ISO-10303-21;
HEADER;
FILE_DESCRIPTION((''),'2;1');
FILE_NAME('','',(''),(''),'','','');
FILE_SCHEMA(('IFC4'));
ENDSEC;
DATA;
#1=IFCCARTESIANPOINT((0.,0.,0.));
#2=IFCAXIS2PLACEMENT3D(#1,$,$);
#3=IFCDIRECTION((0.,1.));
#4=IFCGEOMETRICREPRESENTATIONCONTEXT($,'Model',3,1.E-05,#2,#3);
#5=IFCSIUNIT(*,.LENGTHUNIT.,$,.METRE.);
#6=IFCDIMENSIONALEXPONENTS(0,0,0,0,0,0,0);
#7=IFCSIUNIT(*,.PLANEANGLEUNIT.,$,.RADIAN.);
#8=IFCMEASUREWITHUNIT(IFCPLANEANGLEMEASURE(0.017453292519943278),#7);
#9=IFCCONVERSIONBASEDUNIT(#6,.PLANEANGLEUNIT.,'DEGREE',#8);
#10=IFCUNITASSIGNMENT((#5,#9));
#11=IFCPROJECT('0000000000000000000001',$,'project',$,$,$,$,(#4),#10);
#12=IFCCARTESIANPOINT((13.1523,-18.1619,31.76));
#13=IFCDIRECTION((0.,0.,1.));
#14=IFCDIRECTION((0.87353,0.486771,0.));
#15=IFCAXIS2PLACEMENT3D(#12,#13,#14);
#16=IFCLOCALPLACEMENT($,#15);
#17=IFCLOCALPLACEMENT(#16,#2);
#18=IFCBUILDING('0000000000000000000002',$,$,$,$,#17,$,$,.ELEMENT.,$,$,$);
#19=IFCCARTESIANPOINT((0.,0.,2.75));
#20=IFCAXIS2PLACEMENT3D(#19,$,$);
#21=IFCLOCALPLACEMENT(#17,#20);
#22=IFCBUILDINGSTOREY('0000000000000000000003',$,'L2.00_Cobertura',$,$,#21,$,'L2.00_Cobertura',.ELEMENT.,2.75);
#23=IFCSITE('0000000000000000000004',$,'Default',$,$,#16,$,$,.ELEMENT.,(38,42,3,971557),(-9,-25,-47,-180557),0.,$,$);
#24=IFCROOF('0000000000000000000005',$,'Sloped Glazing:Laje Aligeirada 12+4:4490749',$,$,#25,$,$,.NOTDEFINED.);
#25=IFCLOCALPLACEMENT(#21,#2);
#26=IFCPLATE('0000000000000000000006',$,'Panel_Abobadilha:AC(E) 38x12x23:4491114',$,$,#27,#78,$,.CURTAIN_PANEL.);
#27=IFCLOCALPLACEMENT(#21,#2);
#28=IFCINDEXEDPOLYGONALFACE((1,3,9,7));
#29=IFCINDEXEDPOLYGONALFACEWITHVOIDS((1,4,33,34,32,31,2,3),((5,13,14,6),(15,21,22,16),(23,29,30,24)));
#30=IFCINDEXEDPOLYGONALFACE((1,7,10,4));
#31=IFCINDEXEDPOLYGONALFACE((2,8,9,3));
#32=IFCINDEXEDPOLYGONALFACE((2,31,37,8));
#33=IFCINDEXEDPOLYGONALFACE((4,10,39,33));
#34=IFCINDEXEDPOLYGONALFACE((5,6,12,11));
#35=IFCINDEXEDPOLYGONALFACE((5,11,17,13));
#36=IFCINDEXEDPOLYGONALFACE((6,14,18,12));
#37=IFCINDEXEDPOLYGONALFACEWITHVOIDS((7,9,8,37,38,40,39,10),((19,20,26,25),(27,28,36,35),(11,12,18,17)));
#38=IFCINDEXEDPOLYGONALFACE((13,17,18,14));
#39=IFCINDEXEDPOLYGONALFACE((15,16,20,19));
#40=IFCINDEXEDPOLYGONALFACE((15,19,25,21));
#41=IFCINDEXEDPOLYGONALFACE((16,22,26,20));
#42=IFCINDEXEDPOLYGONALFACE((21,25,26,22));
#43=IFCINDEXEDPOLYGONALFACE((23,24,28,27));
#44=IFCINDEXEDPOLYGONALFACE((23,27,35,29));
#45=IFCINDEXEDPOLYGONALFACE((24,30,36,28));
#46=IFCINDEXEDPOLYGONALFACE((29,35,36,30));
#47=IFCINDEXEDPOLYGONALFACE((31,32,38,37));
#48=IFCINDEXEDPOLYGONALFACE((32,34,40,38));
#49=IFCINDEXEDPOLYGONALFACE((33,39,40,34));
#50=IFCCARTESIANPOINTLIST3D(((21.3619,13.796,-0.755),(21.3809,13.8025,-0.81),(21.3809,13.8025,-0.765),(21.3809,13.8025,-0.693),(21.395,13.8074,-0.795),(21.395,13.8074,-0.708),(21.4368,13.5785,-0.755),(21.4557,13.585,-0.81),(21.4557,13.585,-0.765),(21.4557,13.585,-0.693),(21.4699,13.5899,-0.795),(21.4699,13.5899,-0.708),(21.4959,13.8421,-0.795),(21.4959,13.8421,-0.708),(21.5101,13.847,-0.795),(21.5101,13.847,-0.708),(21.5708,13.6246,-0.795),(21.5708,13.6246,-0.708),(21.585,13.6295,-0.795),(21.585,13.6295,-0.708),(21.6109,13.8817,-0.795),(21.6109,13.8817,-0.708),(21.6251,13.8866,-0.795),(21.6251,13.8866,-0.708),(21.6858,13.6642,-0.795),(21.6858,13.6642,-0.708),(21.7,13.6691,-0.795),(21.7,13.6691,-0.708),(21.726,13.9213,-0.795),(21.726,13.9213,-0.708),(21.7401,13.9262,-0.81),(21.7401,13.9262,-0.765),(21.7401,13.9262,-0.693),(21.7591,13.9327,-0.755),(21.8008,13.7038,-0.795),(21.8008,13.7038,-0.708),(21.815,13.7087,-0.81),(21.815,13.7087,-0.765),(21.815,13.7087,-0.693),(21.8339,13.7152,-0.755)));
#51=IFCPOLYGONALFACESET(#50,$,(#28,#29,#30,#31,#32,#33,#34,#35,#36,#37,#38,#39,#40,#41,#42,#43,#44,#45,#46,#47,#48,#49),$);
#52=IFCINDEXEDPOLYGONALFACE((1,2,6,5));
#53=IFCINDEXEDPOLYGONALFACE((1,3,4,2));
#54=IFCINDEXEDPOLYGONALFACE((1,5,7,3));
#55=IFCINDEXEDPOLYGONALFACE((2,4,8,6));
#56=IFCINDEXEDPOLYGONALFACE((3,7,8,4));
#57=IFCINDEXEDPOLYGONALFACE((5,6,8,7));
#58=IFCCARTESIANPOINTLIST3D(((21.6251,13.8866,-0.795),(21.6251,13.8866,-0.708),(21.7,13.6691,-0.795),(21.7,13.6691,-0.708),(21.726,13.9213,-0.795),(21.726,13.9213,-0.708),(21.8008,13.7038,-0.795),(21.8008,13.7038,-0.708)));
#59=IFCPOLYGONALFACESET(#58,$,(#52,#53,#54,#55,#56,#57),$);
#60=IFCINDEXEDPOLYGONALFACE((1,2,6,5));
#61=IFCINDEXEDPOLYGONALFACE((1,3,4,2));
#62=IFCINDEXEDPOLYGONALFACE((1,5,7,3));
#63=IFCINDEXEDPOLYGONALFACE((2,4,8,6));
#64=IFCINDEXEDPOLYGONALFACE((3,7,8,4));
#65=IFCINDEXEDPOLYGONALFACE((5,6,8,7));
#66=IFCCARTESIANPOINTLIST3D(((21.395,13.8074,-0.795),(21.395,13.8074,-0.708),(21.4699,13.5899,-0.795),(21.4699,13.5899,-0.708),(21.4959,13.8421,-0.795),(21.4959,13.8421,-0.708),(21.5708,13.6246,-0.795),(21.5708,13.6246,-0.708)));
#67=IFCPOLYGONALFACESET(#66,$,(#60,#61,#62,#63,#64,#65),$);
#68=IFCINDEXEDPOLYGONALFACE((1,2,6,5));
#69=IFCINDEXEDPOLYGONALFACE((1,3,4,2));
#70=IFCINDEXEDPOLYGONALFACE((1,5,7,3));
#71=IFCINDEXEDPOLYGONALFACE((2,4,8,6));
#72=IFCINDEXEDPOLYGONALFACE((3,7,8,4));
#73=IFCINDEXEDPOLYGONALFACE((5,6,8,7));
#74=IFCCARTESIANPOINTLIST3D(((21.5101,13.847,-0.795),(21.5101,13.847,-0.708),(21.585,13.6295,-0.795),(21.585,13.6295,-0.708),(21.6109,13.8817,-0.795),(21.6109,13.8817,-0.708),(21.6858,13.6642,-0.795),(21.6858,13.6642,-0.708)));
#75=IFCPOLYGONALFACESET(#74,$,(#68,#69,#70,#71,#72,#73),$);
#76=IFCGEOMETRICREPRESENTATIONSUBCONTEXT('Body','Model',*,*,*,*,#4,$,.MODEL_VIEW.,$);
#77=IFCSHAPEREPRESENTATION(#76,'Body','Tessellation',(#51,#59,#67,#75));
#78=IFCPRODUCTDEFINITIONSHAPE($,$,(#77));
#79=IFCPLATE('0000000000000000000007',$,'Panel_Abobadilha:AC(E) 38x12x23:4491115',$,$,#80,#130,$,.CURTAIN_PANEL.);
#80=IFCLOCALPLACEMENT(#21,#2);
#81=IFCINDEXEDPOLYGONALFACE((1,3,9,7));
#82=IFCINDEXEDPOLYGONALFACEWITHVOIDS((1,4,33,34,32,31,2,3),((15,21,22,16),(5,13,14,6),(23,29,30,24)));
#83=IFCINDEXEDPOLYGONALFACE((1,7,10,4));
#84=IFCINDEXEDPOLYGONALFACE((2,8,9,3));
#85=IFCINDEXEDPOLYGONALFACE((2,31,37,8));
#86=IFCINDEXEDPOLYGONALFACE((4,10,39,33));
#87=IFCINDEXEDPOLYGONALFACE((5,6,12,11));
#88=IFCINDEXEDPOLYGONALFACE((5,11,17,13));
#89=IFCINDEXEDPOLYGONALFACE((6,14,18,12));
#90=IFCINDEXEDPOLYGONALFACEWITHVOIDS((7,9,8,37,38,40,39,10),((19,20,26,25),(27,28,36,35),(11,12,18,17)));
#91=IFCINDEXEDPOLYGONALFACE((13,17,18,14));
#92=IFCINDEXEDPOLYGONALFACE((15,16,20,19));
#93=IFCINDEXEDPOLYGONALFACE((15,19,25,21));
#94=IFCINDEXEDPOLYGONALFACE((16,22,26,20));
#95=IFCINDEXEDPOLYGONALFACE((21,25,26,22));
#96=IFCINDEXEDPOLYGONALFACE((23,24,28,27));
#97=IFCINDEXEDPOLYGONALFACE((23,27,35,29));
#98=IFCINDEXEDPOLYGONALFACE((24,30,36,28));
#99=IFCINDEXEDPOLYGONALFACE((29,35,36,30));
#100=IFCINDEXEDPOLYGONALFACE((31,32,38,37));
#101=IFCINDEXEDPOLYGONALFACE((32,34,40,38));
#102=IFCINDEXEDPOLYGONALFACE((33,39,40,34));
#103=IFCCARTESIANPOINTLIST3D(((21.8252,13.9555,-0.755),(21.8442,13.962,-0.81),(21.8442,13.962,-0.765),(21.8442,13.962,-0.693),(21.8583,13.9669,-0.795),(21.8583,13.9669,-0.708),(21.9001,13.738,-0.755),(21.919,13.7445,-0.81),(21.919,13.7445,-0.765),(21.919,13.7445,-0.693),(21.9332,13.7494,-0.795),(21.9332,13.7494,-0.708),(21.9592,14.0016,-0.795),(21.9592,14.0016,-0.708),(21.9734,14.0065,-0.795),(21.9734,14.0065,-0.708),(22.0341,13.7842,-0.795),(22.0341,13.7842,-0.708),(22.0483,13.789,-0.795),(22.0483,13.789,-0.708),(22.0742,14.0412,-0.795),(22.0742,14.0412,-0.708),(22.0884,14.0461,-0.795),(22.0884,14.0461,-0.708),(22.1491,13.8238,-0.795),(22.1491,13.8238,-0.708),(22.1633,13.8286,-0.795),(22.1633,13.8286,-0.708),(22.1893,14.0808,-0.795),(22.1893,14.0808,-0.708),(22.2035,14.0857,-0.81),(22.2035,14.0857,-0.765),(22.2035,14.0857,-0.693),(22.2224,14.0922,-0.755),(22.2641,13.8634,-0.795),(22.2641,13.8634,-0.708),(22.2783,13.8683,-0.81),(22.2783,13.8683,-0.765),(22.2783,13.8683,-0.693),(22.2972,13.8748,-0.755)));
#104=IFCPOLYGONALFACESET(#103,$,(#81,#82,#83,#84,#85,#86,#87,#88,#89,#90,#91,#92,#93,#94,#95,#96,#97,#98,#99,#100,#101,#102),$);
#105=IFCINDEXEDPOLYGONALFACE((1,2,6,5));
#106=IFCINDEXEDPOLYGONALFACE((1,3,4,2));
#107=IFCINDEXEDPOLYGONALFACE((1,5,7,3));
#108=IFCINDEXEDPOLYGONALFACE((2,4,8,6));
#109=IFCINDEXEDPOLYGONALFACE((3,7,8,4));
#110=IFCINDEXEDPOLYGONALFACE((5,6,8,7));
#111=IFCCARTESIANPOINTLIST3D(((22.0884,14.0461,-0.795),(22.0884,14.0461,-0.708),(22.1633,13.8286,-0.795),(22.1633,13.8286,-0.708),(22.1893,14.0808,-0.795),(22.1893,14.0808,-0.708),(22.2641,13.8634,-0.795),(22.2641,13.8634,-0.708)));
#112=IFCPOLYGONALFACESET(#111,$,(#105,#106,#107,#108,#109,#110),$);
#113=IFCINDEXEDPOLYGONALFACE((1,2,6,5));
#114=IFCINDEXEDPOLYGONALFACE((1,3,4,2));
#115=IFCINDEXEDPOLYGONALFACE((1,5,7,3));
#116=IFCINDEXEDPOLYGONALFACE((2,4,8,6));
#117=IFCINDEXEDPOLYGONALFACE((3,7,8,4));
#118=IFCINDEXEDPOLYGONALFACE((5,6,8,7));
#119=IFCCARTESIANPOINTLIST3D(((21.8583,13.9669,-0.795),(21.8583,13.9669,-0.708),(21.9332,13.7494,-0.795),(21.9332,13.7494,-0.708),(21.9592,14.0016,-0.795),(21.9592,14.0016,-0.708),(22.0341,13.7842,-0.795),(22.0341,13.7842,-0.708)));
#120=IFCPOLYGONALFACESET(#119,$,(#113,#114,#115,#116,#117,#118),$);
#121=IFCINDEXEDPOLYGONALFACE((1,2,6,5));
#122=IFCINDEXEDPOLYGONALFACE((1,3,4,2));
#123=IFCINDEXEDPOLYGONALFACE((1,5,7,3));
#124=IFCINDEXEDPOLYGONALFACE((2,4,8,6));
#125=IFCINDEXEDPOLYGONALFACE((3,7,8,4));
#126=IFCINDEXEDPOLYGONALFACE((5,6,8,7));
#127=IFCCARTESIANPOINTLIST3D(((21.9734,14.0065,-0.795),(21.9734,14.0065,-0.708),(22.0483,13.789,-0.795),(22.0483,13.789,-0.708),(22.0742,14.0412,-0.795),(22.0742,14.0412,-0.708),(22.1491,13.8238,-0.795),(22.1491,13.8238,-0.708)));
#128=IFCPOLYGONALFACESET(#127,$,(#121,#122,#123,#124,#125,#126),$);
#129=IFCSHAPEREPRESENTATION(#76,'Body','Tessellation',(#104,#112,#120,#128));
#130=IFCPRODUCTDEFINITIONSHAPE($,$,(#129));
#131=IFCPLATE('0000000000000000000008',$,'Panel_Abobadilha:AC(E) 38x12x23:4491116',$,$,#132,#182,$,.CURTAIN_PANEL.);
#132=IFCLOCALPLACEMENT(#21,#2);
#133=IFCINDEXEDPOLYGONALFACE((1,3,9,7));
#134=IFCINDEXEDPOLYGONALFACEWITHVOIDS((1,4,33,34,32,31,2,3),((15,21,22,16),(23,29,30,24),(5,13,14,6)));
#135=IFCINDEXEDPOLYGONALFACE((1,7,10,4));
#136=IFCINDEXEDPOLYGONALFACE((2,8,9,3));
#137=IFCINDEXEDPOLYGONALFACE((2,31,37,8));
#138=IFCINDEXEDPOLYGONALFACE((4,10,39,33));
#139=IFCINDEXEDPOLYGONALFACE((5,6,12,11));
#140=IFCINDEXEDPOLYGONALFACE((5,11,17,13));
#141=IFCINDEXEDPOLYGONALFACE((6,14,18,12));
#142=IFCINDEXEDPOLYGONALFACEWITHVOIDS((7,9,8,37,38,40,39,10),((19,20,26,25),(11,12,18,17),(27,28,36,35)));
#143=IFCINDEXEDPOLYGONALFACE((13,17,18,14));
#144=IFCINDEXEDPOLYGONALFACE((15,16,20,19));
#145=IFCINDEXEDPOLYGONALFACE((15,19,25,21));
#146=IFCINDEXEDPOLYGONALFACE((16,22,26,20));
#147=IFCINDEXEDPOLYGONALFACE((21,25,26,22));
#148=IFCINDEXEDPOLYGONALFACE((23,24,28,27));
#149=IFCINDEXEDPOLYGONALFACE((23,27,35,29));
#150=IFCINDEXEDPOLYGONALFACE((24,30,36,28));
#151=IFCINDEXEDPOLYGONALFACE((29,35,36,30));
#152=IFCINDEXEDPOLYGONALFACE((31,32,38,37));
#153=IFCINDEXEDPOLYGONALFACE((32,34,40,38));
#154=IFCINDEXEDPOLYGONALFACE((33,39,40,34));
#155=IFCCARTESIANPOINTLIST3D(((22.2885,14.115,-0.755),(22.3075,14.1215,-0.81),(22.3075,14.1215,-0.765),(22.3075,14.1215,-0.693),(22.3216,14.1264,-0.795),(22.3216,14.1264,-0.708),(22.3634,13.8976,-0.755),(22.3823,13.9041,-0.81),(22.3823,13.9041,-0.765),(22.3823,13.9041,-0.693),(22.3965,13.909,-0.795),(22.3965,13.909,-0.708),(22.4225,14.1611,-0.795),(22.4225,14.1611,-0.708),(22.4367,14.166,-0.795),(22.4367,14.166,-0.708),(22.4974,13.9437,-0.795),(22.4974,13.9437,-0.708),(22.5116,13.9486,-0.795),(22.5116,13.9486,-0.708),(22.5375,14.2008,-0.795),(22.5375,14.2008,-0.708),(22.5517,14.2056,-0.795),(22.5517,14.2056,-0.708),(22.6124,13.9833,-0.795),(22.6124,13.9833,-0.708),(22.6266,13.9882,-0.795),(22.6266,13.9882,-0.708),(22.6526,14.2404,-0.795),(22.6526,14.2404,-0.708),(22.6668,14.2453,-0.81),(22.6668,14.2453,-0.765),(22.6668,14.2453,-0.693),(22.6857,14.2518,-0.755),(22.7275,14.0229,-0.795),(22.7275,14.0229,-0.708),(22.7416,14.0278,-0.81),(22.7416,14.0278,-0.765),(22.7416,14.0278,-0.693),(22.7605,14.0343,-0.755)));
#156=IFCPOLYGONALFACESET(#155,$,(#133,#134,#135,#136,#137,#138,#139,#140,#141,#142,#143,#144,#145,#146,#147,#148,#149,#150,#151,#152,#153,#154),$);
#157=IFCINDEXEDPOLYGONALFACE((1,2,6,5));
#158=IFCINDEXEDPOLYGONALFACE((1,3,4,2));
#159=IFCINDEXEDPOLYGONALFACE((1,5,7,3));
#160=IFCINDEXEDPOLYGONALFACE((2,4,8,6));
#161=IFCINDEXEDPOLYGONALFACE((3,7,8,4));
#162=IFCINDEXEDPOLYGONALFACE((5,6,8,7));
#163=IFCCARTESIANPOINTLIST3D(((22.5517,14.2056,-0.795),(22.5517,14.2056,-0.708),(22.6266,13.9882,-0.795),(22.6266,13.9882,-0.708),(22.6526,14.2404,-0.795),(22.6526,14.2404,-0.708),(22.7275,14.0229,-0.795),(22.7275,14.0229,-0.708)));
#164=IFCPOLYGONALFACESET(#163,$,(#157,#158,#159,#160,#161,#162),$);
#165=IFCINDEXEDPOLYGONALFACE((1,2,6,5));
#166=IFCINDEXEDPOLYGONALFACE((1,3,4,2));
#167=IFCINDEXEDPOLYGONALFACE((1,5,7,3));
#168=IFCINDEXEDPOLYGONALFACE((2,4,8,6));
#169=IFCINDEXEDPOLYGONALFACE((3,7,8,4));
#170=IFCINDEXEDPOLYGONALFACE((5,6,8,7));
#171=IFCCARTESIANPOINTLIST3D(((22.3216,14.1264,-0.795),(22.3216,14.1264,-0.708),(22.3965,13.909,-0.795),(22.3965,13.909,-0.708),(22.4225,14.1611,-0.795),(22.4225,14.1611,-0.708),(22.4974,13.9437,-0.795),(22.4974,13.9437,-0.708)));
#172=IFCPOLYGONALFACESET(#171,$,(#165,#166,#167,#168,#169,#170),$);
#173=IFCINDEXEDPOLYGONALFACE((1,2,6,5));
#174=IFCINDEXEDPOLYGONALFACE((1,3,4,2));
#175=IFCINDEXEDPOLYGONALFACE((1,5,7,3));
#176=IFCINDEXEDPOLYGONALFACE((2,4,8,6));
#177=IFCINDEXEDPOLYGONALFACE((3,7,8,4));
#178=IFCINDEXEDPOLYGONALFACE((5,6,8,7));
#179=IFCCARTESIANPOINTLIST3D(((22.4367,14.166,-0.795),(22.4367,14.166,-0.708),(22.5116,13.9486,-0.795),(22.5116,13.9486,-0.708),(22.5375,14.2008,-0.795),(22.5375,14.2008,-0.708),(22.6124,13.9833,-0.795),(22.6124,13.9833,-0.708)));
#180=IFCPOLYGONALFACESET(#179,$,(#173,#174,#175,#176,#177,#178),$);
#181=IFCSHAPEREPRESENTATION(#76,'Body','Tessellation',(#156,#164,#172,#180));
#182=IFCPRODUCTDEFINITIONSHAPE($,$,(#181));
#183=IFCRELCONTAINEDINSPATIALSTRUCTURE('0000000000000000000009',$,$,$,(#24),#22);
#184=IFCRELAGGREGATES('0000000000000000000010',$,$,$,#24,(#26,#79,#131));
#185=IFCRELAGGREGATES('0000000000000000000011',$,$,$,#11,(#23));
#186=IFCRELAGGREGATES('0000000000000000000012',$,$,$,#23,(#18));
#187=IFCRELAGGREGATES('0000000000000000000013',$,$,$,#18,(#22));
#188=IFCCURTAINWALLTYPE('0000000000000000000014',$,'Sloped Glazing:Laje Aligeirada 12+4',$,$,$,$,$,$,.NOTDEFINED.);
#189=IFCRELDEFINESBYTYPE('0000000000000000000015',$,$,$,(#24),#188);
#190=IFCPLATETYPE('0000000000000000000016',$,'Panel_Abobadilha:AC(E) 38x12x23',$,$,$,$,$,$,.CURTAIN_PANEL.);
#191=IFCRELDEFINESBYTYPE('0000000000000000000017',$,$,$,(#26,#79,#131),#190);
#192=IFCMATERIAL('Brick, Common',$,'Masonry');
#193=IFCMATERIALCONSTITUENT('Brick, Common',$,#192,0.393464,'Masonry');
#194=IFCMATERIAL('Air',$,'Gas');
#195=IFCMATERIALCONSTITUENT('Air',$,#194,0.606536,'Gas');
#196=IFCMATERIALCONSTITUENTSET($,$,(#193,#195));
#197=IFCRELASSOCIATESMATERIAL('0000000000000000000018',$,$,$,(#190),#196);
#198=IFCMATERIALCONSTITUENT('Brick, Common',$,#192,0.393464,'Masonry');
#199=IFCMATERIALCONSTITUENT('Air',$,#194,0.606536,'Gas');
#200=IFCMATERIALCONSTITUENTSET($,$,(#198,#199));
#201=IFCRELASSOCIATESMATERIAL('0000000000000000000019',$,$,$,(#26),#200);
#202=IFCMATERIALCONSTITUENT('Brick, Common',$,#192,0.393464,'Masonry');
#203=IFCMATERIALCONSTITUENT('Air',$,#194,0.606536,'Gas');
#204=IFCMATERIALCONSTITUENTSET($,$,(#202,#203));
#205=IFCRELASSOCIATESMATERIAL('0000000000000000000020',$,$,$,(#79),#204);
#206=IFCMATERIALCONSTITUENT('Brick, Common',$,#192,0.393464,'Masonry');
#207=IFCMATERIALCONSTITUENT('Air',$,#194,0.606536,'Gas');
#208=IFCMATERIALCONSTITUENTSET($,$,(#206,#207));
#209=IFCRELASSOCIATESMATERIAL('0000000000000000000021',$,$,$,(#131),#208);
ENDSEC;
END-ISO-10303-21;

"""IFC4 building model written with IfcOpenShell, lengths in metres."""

from ifc_helpers import new_model, entity, si_unit, converted_unit, direction, frame, origin, place, context, subcontext, project, spatial, indexed_curve, outline, extrude, source, transform, mapped, material, constituent, constituent_set, type_object, type_shapes, element, aggregate, save


model = new_model("IFC4")

# Units and contexts
model_context = context("Model", 3, precision=1e-05, world=origin(), true_north=direction((0.0, 1.0)))
body_context = subcontext(model_context, "Body", "Model", "MODEL_VIEW")
ifc_project = project(units=[si_unit("LENGTHUNIT", "METRE"), converted_unit("PLANEANGLEUNIT", "DEGREE", entity("IfcPlaneAngleMeasure", 0.017453292519943278), si_unit("PLANEANGLEUNIT", "RADIAN"), dimensions=[0, 0, 0, 0, 0, 0, 0])], contexts=[model_context])

# Site, building, storey
site_placement = place(None, frame((13.1523, -18.1619, 31.76), z_axis=(0.0, 0.0, 1.0), x_axis=(0.87353, 0.486771, 0.0)))
site = spatial("IfcSite", under=ifc_project, at=site_placement, Name="Default", CompositionType="ELEMENT", RefLatitude=(38, 42, 3, 971557), RefLongitude=(-9, -25, -47, -180557), RefElevation=0.0)
building_placement = place(site_placement, origin())
building = spatial("IfcBuilding", under=site, at=building_placement, CompositionType="ELEMENT")
storey_placement = place(building_placement, frame((0.0, 0.0, 2.75)))
storey = spatial("IfcBuildingStorey", under=building, at=storey_placement, Name="L2.00_Cobertura", LongName="L2.00_Cobertura", CompositionType="ELEMENT", Elevation=2.75)

# Roof, plates
curtain_wall_type = type_object("IfcCurtainWallType", Name="Sloped Glazing:Laje Aligeirada 12+4", PredefinedType="NOTDEFINED")
roof_placement = place(storey_placement, frame((0.0, 0.0, -2.75)))
roof = element("IfcRoof", 1, at=roof_placement, inside=storey, type_object=curtain_wall_type, Name="Sloped Glazing:Laje Aligeirada 12+4:4490749", PredefinedType="NOTDEFINED")
ifc_material_1 = material(Name="Brick, Common", Category="Masonry")
ifc_material_2 = material(Name="Air", Category="Gas")
ifc_constituent_1 = constituent(ifc_material_1, Name="Brick, Common", Category="Masonry", fraction=0.393464)
ifc_constituent_2 = constituent(ifc_material_2, Name="Air", Category="Gas", fraction=0.606536)
ifc_constituent_set_1 = constituent_set(constituents=[ifc_constituent_1, ifc_constituent_2])
plate_type = type_object("IfcPlateType", Name="Panel_Abobadilha:AC(E) 38x12x23", PredefinedType="CURTAIN_PANEL", material=ifc_constituent_set_1)
shared_shape_1 = source(origin(), body_context, "Body", "SweptSolid", [
    extrude(outline(indexed_curve([(-0.19, -0.0543), (0.19, -0.0543), (0.19, -0.0093), (0.21, 0.0007), (0.19, 0.0628), (-0.19, 0.0628), (-0.21, 0.0007), (-0.19, -0.0093), (-0.19, -0.0543)], self_intersect=False), holes=[indexed_curve([(-0.0683, 0.0477), (-0.0683, -0.0393), (-0.175, -0.0393), (-0.175, 0.0477), (-0.0683, 0.0477)], self_intersect=False), indexed_curve([(0.0533, 0.0477), (0.0533, -0.0393), (-0.0533, -0.0393), (-0.0533, 0.0477), (0.0533, 0.0477)], self_intersect=False), indexed_curve([(0.175, 0.0477), (0.175, -0.0393), (0.0683, -0.0393), (0.0683, 0.0477), (0.175, 0.0477)], self_intersect=False)]), frame((0.0, 0.0543, 0.0)), (0.0, 0.0, 1.0), 0.23),
    extrude(outline(indexed_curve([(-0.0533, -0.0435), (0.0533, -0.0435), (0.0533, 0.0435), (-0.0533, 0.0435), (-0.0533, -0.0435)], self_intersect=False)), frame((0.1217, 0.0585, 0.0), z_axis=(0.0, 0.0, 1.0), x_axis=(-1.0, 0.0, 0.0)), (0.0, 0.0, 1.0), 0.23),
    extrude(outline(indexed_curve([(-0.0533, -0.0435), (0.0533, -0.0435), (0.0533, 0.0435), (-0.0533, 0.0435), (-0.0533, -0.0435)], self_intersect=False)), frame((-0.1217, 0.0585, 0.0), z_axis=(0.0, 0.0, 1.0), x_axis=(-1.0, 0.0, 0.0)), (0.0, 0.0, 1.0), 0.23),
    extrude(outline(indexed_curve([(-0.0533, -0.0435), (0.0533, -0.0435), (0.0533, 0.0435), (-0.0533, 0.0435), (-0.0533, -0.0435)], self_intersect=False)), frame((0.0, 0.0585, 0.0), z_axis=(0.0, 0.0, 1.0), x_axis=(-1.0, 0.0, 0.0)), (0.0, 0.0, 1.0), 0.23),
])
type_shapes(plate_type, [shared_shape_1])
ifc_constituent_3 = constituent(ifc_material_1, Name="Brick, Common", Category="Masonry", fraction=0.393464)
ifc_constituent_4 = constituent(ifc_material_2, Name="Air", Category="Gas", fraction=0.606536)
ifc_constituent_set_2 = constituent_set(constituents=[ifc_constituent_3, ifc_constituent_4])
plate_1_placement = place(roof_placement, frame((21.5605, 13.8643, 1.94), z_axis=(0.325568, -0.945519, 0.0), x_axis=(0.945519, 0.325568, 0.0)))
plate_1 = element("IfcPlate", 2, at=plate_1_placement, type_object=plate_type, material=ifc_constituent_set_2, Name="Panel_Abobadilha:AC(E) 38x12x23:4491114", PredefinedType="CURTAIN_PANEL", context=body_context, shape_type="MappedRepresentation", body=[
    mapped(shared_shape_1, transform((0.0, 0.0, 0.0), scale=1.0)),
])
ifc_constituent_5 = constituent(ifc_material_1, Name="Brick, Common", Category="Masonry", fraction=0.393464)
ifc_constituent_6 = constituent(ifc_material_2, Name="Air", Category="Gas", fraction=0.606536)
ifc_constituent_set_3 = constituent_set(constituents=[ifc_constituent_5, ifc_constituent_6])
plate_2_placement = place(roof_placement, frame((22.0238, 14.0239, 1.94), z_axis=(0.325568, -0.945519, 0.0), x_axis=(0.945519, 0.325568, 0.0)))
plate_2 = element("IfcPlate", 3, at=plate_2_placement, type_object=plate_type, material=ifc_constituent_set_3, Name="Panel_Abobadilha:AC(E) 38x12x23:4491115", PredefinedType="CURTAIN_PANEL", context=body_context, shape_type="MappedRepresentation", body=[
    mapped(shared_shape_1, transform((0.0, 0.0, 0.0), scale=1.0)),
])
ifc_constituent_7 = constituent(ifc_material_1, Name="Brick, Common", Category="Masonry", fraction=0.393464)
ifc_constituent_8 = constituent(ifc_material_2, Name="Air", Category="Gas", fraction=0.606536)
ifc_constituent_set_4 = constituent_set(constituents=[ifc_constituent_7, ifc_constituent_8])
plate_3_placement = place(roof_placement, frame((22.4871, 14.1834, 1.94), z_axis=(0.325568, -0.945519, 0.0), x_axis=(0.945519, 0.325568, 0.0)))
plate_3 = element("IfcPlate", 4, at=plate_3_placement, type_object=plate_type, material=ifc_constituent_set_4, Name="Panel_Abobadilha:AC(E) 38x12x23:4491116", PredefinedType="CURTAIN_PANEL", context=body_context, shape_type="MappedRepresentation", body=[
    mapped(shared_shape_1, transform((0.0, 0.0, 0.0), scale=1.0)),
])
aggregate(roof, [plate_1, plate_2, plate_3])

save(model, "model.ifc")
